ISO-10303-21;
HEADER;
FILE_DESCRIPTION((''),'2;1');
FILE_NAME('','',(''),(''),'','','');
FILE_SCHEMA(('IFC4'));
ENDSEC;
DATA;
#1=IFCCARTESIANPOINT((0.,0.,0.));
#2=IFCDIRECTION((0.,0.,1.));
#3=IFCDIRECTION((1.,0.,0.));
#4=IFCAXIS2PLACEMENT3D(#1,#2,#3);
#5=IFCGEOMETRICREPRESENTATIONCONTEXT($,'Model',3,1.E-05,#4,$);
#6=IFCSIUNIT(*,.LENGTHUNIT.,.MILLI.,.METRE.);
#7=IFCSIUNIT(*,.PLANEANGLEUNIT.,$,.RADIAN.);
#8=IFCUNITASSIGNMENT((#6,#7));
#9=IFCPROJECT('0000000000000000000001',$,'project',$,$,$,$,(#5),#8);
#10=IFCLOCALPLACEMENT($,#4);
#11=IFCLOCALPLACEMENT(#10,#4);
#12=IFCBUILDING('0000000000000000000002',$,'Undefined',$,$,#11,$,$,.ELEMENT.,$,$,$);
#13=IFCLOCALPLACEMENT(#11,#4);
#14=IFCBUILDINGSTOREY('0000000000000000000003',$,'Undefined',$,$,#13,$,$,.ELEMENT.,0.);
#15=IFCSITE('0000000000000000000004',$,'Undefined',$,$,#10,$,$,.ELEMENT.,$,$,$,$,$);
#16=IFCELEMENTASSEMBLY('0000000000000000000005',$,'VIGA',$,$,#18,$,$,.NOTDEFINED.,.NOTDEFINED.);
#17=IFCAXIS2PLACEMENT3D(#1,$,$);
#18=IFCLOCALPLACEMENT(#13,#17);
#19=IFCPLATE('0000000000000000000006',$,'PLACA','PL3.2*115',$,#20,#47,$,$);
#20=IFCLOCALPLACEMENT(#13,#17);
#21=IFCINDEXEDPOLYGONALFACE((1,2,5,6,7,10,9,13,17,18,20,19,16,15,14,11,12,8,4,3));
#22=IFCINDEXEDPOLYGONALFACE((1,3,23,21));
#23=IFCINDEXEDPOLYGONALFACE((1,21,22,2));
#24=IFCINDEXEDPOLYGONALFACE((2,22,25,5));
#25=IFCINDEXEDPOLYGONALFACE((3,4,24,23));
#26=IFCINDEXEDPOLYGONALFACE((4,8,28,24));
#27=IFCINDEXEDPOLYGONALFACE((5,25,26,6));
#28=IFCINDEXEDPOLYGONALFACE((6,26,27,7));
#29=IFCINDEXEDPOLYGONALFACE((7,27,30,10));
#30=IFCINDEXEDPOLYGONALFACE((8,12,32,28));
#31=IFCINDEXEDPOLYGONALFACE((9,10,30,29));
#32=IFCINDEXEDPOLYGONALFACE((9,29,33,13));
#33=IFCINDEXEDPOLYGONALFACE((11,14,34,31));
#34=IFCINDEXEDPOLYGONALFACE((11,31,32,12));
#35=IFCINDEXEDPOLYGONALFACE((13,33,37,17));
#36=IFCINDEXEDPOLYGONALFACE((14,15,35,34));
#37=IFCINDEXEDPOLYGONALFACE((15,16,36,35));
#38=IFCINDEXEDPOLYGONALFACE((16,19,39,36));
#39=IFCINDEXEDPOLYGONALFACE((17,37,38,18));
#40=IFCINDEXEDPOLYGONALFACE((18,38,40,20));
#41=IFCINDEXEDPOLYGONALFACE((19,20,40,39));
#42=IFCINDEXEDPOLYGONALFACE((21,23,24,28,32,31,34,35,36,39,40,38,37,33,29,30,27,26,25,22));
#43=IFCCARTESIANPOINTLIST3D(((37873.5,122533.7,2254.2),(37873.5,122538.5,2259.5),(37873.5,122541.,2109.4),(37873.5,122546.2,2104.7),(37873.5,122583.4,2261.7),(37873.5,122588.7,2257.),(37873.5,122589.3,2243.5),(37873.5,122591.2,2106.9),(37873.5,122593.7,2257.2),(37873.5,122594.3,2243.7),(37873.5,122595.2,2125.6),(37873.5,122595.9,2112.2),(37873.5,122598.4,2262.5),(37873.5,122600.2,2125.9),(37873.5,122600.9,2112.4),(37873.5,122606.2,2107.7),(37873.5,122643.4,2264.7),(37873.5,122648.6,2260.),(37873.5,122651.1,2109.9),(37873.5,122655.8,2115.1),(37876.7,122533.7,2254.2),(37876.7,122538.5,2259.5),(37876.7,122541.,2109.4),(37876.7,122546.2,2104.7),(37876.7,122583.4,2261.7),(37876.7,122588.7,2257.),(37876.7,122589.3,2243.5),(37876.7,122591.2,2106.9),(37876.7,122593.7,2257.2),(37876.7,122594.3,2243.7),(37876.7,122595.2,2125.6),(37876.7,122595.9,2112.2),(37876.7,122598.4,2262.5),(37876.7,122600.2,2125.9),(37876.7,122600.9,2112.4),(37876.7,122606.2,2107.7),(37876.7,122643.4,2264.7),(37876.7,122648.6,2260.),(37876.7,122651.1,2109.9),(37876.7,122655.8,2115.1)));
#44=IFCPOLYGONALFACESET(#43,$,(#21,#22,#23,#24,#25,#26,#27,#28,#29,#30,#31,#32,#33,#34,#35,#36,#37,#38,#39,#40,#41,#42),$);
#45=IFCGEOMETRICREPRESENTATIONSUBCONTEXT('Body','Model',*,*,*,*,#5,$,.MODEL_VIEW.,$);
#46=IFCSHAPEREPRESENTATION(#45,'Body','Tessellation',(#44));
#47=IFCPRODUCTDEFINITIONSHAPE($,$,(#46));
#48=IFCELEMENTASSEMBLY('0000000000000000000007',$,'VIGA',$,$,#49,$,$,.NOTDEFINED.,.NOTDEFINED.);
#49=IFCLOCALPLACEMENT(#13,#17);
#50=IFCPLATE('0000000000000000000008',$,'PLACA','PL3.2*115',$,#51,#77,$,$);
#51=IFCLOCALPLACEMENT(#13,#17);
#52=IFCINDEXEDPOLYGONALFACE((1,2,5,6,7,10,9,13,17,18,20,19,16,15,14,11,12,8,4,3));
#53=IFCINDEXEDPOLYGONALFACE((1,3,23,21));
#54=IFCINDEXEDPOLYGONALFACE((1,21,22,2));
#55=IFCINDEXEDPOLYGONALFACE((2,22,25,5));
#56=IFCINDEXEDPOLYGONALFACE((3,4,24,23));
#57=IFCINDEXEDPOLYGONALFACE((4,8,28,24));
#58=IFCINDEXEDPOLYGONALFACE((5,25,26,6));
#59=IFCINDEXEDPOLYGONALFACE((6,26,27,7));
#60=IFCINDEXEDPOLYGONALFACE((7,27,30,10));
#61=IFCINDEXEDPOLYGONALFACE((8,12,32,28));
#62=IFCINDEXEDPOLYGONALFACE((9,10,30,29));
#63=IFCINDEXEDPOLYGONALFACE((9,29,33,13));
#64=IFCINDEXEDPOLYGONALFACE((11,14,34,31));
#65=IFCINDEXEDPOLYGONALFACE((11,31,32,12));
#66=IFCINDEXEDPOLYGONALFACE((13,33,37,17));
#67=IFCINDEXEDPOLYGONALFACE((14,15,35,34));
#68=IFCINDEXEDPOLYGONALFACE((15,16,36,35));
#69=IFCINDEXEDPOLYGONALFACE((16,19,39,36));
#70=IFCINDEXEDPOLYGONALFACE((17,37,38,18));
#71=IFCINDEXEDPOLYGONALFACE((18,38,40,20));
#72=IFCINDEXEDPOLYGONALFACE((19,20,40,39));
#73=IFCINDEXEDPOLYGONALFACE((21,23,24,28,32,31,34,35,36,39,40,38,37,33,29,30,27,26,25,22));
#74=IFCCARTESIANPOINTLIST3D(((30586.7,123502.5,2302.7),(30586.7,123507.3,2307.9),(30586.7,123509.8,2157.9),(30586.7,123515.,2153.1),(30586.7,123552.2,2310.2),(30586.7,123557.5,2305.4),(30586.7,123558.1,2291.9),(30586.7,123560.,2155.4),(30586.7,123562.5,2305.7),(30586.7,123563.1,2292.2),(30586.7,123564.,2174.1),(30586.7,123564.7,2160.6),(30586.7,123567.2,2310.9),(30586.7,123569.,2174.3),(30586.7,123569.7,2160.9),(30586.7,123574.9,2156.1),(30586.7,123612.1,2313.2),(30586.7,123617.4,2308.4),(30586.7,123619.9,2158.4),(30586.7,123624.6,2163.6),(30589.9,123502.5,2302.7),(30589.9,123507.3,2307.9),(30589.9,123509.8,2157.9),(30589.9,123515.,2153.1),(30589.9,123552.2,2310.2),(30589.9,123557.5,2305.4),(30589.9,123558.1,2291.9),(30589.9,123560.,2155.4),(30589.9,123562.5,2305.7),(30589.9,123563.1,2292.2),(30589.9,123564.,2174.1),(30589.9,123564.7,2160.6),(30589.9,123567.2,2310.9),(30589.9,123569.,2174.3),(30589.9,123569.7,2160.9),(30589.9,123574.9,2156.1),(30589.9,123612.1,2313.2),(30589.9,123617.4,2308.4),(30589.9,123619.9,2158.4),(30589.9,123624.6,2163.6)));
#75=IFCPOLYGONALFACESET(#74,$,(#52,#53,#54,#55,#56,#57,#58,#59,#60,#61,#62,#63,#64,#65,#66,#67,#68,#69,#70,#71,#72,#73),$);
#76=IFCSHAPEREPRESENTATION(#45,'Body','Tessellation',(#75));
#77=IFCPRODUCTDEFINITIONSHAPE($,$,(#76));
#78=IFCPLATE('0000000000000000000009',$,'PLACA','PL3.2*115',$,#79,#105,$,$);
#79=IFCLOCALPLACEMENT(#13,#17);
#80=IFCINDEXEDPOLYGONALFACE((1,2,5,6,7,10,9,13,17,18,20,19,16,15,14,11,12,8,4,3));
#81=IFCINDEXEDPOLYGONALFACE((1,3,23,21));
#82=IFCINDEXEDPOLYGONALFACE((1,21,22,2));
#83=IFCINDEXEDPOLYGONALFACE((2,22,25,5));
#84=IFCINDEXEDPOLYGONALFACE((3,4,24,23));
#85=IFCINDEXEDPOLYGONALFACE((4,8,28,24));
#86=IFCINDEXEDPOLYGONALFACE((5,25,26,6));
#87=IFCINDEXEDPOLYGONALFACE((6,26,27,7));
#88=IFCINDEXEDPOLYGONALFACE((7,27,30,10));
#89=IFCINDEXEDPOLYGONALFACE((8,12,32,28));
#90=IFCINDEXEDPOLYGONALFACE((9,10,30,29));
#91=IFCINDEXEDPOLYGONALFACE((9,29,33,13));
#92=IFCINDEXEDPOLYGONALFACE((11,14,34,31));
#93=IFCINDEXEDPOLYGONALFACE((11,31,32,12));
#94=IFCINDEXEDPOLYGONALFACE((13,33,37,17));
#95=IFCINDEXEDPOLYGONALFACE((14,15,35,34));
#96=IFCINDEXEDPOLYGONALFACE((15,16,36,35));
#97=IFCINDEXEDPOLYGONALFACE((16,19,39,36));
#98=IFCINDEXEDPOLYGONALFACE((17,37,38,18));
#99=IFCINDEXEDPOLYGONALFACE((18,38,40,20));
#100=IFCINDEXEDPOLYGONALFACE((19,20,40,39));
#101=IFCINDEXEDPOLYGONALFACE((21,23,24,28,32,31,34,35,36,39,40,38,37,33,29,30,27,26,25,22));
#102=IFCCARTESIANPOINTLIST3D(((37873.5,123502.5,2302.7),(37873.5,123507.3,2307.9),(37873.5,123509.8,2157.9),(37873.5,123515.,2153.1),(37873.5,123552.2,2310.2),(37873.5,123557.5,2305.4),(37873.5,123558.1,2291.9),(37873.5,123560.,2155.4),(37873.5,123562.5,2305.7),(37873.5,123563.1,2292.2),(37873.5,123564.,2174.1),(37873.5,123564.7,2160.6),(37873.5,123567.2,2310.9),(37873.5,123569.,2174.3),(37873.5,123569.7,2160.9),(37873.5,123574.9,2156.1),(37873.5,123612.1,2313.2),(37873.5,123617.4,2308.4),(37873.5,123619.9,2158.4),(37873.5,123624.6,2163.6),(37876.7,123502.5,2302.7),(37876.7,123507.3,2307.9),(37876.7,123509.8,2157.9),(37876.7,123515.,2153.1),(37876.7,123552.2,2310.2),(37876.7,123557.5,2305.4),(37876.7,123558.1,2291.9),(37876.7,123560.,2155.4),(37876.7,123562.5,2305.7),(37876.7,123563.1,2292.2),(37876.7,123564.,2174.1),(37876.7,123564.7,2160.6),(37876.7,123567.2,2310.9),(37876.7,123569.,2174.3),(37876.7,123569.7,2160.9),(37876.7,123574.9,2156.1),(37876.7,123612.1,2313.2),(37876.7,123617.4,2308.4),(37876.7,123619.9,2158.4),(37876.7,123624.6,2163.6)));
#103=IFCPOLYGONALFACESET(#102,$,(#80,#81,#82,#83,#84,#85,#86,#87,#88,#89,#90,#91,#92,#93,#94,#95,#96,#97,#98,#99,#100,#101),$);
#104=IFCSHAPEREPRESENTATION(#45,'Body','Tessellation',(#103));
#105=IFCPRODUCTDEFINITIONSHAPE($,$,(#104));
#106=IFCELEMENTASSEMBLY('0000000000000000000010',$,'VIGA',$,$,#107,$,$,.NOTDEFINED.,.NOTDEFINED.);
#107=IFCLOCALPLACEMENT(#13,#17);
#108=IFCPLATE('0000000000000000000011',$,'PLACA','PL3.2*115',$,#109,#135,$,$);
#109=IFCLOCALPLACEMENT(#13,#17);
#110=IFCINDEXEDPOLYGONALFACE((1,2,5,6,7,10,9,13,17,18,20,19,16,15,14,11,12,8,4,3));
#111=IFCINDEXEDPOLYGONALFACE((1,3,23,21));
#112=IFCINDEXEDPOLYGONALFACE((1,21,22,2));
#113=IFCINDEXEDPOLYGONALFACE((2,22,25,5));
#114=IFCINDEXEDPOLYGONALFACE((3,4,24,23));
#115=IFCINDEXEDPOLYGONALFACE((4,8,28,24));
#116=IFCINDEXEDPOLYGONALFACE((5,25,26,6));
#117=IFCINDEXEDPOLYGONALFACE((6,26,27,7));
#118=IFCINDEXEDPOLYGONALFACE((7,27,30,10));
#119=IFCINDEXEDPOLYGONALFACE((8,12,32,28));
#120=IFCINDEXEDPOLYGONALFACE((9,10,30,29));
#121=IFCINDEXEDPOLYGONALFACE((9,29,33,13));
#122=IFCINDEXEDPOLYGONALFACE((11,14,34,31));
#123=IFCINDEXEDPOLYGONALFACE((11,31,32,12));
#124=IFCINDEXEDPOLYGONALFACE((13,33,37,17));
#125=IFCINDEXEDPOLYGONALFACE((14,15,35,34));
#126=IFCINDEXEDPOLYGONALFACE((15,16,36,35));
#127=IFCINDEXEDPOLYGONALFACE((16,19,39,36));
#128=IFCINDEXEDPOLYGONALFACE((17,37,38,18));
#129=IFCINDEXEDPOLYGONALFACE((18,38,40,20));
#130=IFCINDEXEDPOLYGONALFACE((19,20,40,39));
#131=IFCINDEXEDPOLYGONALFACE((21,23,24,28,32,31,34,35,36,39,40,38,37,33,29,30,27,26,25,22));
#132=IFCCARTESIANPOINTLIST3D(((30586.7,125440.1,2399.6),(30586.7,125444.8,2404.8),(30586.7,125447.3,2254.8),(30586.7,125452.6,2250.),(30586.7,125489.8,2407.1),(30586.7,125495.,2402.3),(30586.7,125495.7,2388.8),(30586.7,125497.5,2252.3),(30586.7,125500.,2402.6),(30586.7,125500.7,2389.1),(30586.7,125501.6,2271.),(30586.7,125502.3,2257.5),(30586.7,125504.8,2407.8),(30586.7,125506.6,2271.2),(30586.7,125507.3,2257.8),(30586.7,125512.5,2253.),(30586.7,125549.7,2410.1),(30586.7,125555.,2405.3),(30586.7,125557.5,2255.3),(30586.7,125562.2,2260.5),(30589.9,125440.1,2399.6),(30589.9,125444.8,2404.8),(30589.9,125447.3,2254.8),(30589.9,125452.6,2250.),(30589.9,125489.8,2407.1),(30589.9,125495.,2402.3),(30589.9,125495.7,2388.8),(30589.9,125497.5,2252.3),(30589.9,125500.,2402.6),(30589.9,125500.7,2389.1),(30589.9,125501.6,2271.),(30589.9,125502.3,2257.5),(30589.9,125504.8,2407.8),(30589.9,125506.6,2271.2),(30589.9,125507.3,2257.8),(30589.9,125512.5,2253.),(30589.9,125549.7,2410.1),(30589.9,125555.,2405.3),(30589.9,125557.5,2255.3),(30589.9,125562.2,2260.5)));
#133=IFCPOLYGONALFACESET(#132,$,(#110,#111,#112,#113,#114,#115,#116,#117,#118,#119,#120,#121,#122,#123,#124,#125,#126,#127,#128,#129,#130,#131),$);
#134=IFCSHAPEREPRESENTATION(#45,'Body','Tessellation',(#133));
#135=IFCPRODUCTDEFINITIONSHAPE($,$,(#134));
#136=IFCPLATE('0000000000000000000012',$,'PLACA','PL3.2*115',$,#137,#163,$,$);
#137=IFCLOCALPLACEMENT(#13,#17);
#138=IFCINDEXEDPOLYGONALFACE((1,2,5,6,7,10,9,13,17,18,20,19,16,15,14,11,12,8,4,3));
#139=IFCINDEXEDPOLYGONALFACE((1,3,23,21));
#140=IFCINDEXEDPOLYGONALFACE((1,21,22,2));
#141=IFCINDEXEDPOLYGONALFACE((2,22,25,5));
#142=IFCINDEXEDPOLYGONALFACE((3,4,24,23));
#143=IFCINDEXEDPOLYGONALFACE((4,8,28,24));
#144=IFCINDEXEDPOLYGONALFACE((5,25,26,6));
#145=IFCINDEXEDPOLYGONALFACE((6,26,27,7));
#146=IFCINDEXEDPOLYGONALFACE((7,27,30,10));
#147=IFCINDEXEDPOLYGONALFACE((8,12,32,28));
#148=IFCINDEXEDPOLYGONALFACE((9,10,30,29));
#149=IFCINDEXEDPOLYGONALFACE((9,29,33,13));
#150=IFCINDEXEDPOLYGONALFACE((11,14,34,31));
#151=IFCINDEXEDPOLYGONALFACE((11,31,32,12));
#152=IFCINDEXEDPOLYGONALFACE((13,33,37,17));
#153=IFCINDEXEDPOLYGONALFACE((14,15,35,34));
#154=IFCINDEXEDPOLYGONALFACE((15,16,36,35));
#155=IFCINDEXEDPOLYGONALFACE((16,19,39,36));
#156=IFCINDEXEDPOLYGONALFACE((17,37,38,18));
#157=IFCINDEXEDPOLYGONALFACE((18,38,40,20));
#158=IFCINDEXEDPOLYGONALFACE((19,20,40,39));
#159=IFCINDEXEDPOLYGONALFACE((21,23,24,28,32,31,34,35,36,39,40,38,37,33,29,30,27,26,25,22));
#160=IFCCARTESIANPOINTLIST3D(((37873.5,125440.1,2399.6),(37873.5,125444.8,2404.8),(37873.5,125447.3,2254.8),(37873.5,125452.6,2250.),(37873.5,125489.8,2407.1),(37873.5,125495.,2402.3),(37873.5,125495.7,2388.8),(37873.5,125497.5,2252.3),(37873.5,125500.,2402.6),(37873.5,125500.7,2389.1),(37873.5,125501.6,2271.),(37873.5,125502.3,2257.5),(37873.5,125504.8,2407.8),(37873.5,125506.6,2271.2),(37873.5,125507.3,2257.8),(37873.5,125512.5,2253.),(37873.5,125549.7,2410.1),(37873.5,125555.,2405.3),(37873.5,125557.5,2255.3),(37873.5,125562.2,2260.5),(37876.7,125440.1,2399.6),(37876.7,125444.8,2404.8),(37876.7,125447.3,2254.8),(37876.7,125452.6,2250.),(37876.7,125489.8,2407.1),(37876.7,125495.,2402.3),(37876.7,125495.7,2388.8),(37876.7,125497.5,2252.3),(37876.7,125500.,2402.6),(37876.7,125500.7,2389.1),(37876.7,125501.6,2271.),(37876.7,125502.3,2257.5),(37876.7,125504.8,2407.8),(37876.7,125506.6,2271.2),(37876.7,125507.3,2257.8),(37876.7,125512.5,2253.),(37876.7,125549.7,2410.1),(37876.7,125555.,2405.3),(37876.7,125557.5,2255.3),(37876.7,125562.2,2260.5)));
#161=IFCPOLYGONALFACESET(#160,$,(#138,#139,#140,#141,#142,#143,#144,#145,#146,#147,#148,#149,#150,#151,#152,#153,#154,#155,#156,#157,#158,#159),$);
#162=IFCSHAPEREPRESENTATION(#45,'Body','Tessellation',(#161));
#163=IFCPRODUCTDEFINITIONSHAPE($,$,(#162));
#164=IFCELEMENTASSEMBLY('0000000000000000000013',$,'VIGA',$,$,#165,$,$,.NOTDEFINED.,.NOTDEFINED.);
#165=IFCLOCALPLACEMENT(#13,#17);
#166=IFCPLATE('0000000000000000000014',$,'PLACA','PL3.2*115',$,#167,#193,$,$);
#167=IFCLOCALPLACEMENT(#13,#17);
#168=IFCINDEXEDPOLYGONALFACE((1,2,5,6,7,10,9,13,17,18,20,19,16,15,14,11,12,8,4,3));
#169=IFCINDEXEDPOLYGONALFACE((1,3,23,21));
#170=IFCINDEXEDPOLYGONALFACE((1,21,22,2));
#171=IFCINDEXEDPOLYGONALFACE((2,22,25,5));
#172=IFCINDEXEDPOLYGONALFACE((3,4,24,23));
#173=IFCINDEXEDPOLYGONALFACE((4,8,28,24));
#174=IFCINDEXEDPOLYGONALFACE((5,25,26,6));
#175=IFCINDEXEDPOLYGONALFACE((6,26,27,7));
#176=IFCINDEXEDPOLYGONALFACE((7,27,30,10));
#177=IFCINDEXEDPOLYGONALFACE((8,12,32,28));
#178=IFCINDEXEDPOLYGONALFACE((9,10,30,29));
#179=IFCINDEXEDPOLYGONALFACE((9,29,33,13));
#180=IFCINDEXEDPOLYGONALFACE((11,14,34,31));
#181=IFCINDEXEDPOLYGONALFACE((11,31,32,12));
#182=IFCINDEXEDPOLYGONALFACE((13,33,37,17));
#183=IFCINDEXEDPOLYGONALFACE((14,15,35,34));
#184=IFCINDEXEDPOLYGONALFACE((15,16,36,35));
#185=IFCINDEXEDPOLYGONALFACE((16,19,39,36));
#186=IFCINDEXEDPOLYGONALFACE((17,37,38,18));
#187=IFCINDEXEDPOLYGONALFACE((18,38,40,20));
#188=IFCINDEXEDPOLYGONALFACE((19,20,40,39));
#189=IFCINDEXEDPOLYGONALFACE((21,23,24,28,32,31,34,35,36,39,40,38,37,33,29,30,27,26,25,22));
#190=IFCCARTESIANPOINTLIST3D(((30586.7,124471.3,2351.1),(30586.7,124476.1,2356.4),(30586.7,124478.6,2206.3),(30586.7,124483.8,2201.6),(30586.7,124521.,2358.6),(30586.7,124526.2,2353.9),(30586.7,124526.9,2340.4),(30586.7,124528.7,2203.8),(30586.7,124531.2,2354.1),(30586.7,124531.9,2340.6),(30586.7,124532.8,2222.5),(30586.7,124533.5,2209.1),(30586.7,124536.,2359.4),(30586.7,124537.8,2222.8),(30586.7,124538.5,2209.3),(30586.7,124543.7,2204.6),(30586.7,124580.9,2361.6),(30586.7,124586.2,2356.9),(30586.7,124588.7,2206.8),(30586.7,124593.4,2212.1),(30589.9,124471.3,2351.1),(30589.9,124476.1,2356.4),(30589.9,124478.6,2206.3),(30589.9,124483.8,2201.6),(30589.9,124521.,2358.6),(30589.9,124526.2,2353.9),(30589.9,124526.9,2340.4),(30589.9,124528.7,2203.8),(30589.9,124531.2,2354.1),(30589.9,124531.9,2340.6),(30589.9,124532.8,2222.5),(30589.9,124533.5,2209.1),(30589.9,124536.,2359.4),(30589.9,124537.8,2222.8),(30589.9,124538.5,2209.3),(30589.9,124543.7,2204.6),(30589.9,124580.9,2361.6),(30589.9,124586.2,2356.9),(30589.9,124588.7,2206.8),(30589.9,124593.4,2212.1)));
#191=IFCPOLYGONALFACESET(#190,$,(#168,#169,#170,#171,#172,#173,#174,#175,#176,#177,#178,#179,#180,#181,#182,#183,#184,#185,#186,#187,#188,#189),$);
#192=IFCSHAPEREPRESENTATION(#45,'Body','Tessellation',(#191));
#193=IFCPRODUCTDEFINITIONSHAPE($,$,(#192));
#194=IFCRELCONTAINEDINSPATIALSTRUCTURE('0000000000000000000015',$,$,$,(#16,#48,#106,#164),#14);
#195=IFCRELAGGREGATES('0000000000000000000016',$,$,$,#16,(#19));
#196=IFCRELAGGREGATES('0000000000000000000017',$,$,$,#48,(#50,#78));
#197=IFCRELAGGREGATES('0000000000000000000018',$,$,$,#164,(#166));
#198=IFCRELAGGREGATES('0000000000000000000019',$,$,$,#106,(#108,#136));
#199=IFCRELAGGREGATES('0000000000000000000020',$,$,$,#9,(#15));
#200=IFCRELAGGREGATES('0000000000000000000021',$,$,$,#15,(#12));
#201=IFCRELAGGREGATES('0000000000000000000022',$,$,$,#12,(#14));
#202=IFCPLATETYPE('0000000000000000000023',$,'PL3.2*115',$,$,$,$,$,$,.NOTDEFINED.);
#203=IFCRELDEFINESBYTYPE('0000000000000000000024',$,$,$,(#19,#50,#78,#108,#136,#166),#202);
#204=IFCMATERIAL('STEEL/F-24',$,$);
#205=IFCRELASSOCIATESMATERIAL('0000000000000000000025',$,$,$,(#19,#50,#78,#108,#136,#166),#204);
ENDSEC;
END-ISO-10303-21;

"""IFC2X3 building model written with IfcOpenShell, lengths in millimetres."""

from ifc_helpers import new_model, si_unit, frame, origin_with_axes, place, context, subcontext, project, spatial, polyline, outline, extrude, material, type_object, element, aggregate, save


model = new_model("IFC2X3")

# Units and contexts
model_context = context("Model", 3, precision=1e-05, world=origin_with_axes())
body_context = subcontext(model_context, "Body", "Model", "MODEL_VIEW")
ifc_project = project(units=[si_unit("LENGTHUNIT", "METRE", prefix="MILLI"), si_unit("PLANEANGLEUNIT", "RADIAN")], contexts=[model_context])

# Site, building, storey
site_placement = place(None, origin_with_axes())
site = spatial("IfcSite", under=ifc_project, at=site_placement, Name="Undefined", CompositionType="ELEMENT")
building_placement = place(site_placement, origin_with_axes())
building = spatial("IfcBuilding", under=site, at=building_placement, Name="Undefined", CompositionType="ELEMENT")
storey_placement = place(building_placement, origin_with_axes())
storey = spatial("IfcBuildingStorey", under=building, at=storey_placement, Name="Undefined", CompositionType="ELEMENT", Elevation=0.0)

# Shared definitions
ifc_material_1 = material(Name="STEEL/F-24")

# Element assembly, plate
plate_type_1 = type_object("IfcPlateType", Name="PL3.2*115", PredefinedType="NOTDEFINED")
assembly_1_placement = place(storey_placement, origin_with_axes())
assembly_1 = element("IfcElementAssembly", 1, at=assembly_1_placement, inside=storey, Name="VIGA", AssemblyPlace="NOTDEFINED", PredefinedType="NOTDEFINED")
plate_1_placement = place(assembly_1_placement, frame((37875.1, 122533.5, 2259.2), z_axis=(-1.0, 0.0, 0.0), x_axis=(0.0, 0.998752, 0.04995)))
plate_1 = element("IfcPlate", 2, at=plate_1_placement, type_object=plate_type_1, material=ifc_material_1, Name="PLACA", Description="PL3.2*115", context=body_context, shape_type="SweptSolid", body=[
    extrude(outline(polyline([(0.0, 5.0), (5.0, 0.0), (50.0, 0.0), (55.0, 5.0), (55.0, 18.5), (60.0, 18.5), (60.0, 5.0), (65.0, 0.0), (110.0, 0.0), (115.0, 5.0), (115.0, 150.0), (110.0, 155.0), (65.0, 155.0), (60.0, 150.0), (60.0, 136.5), (55.0, 136.5), (55.0, 150.0), (50.0, 155.0), (5.0, 155.0), (0.0, 150.0), (0.0, 5.0)])), frame((0.0, 0.0, -1.6), z_axis=(0.0, 0.0, 1.0), x_axis=(1.0, 0.0, 0.0)), (0.0, 0.0, 1.0), 3.2),
])

# Element assemblies, plates
assembly_2_placement = place(storey_placement, origin_with_axes())
assembly_2 = element("IfcElementAssembly", 3, at=assembly_2_placement, inside=storey, Name="VIGA", AssemblyPlace="NOTDEFINED", PredefinedType="NOTDEFINED")
plate_2_placement = place(assembly_2_placement, frame((30588.3, 123502.3, 2307.7), z_axis=(-1.0, 0.0, 0.0), x_axis=(0.0, 0.998752, 0.04995)))
plate_2 = element("IfcPlate", 4, at=plate_2_placement, type_object=plate_type_1, material=ifc_material_1, Name="PLACA", Description="PL3.2*115", context=body_context, shape_type="SweptSolid", body=[
    extrude(outline(polyline([(0.0, 5.0), (5.0, 0.0), (50.0, 0.0), (55.0, 5.0), (55.0, 18.5), (60.0, 18.5), (60.0, 5.0), (65.0, 0.0), (110.0, 0.0), (115.0, 5.0), (115.0, 150.0), (110.0, 155.0), (65.0, 155.0), (60.0, 150.0), (60.0, 136.5), (55.0, 136.5), (55.0, 150.0), (50.0, 155.0), (5.0, 155.0), (0.0, 150.0), (0.0, 5.0)])), frame((0.0, 0.0, -1.6), z_axis=(0.0, 0.0, 1.0), x_axis=(1.0, 0.0, 0.0)), (0.0, 0.0, 1.0), 3.2),
])
plate_3_placement = place(assembly_2_placement, frame((37875.1, 123502.3, 2307.7), z_axis=(-1.0, 0.0, 0.0), x_axis=(0.0, 0.998752, 0.04995)))
plate_3 = element("IfcPlate", 5, at=plate_3_placement, type_object=plate_type_1, material=ifc_material_1, Name="PLACA", Description="PL3.2*115", context=body_context, shape_type="SweptSolid", body=[
    extrude(outline(polyline([(0.0, 5.0), (5.0, 0.0), (50.0, 0.0), (55.0, 5.0), (55.0, 18.5), (60.0, 18.5), (60.0, 5.0), (65.0, 0.0), (110.0, 0.0), (115.0, 5.0), (115.0, 150.0), (110.0, 155.0), (65.0, 155.0), (60.0, 150.0), (60.0, 136.5), (55.0, 136.5), (55.0, 150.0), (50.0, 155.0), (5.0, 155.0), (0.0, 150.0), (0.0, 5.0)])), frame((0.0, 0.0, -1.6), z_axis=(0.0, 0.0, 1.0), x_axis=(1.0, 0.0, 0.0)), (0.0, 0.0, 1.0), 3.2),
])
assembly_3_placement = place(storey_placement, origin_with_axes())
assembly_3 = element("IfcElementAssembly", 6, at=assembly_3_placement, inside=storey, Name="VIGA", AssemblyPlace="NOTDEFINED", PredefinedType="NOTDEFINED")
plate_4_placement = place(assembly_3_placement, frame((30588.3, 125439.9, 2404.6), z_axis=(-1.0, 0.0, 0.0), x_axis=(0.0, 0.998752, 0.04995)))
plate_4 = element("IfcPlate", 7, at=plate_4_placement, type_object=plate_type_1, material=ifc_material_1, Name="PLACA", Description="PL3.2*115", context=body_context, shape_type="SweptSolid", body=[
    extrude(outline(polyline([(0.0, 5.0), (5.0, 0.0), (50.0, 0.0), (55.0, 5.0), (55.0, 18.5), (60.0, 18.5), (60.0, 5.0), (65.0, 0.0), (110.0, 0.0), (115.0, 5.0), (115.0, 150.0), (110.0, 155.0), (65.0, 155.0), (60.0, 150.0), (60.0, 136.5), (55.0, 136.5), (55.0, 150.0), (50.0, 155.0), (5.0, 155.0), (0.0, 150.0), (0.0, 5.0)])), frame((0.0, 0.0, -1.6), z_axis=(0.0, 0.0, 1.0), x_axis=(1.0, 0.0, 0.0)), (0.0, 0.0, 1.0), 3.2),
])
plate_5_placement = place(assembly_3_placement, frame((37875.1, 125439.9, 2404.6), z_axis=(-1.0, 0.0, 0.0), x_axis=(0.0, 0.998752, 0.04995)))
plate_5 = element("IfcPlate", 8, at=plate_5_placement, type_object=plate_type_1, material=ifc_material_1, Name="PLACA", Description="PL3.2*115", context=body_context, shape_type="SweptSolid", body=[
    extrude(outline(polyline([(0.0, 5.0), (5.0, 0.0), (50.0, 0.0), (55.0, 5.0), (55.0, 18.5), (60.0, 18.5), (60.0, 5.0), (65.0, 0.0), (110.0, 0.0), (115.0, 5.0), (115.0, 150.0), (110.0, 155.0), (65.0, 155.0), (60.0, 150.0), (60.0, 136.5), (55.0, 136.5), (55.0, 150.0), (50.0, 155.0), (5.0, 155.0), (0.0, 150.0), (0.0, 5.0)])), frame((0.0, 0.0, -1.6), z_axis=(0.0, 0.0, 1.0), x_axis=(1.0, 0.0, 0.0)), (0.0, 0.0, 1.0), 3.2),
])
assembly_4_placement = place(storey_placement, origin_with_axes())
assembly_4 = element("IfcElementAssembly", 9, at=assembly_4_placement, inside=storey, Name="VIGA", AssemblyPlace="NOTDEFINED", PredefinedType="NOTDEFINED")
plate_6_placement = place(assembly_4_placement, frame((30588.3, 124471.1, 2356.1), z_axis=(-1.0, 0.0, 0.0), x_axis=(0.0, 0.998752, 0.04995)))
plate_6 = element("IfcPlate", 10, at=plate_6_placement, type_object=plate_type_1, material=ifc_material_1, Name="PLACA", Description="PL3.2*115", context=body_context, shape_type="SweptSolid", body=[
    extrude(outline(polyline([(0.0, 5.0), (5.0, 0.0), (50.0, 0.0), (55.0, 5.0), (55.0, 18.5), (60.0, 18.5), (60.0, 5.0), (65.0, 0.0), (110.0, 0.0), (115.0, 5.0), (115.0, 150.0), (110.0, 155.0), (65.0, 155.0), (60.0, 150.0), (60.0, 136.5), (55.0, 136.5), (55.0, 150.0), (50.0, 155.0), (5.0, 155.0), (0.0, 150.0), (0.0, 5.0)])), frame((0.0, 0.0, -1.6), z_axis=(0.0, 0.0, 1.0), x_axis=(1.0, 0.0, 0.0)), (0.0, 0.0, 1.0), 3.2),
])

aggregate(assembly_1, [plate_1])
aggregate(assembly_2, [plate_2, plate_3])
aggregate(assembly_4, [plate_6])
aggregate(assembly_3, [plate_4, plate_5])

save(model, "model.ifc")
